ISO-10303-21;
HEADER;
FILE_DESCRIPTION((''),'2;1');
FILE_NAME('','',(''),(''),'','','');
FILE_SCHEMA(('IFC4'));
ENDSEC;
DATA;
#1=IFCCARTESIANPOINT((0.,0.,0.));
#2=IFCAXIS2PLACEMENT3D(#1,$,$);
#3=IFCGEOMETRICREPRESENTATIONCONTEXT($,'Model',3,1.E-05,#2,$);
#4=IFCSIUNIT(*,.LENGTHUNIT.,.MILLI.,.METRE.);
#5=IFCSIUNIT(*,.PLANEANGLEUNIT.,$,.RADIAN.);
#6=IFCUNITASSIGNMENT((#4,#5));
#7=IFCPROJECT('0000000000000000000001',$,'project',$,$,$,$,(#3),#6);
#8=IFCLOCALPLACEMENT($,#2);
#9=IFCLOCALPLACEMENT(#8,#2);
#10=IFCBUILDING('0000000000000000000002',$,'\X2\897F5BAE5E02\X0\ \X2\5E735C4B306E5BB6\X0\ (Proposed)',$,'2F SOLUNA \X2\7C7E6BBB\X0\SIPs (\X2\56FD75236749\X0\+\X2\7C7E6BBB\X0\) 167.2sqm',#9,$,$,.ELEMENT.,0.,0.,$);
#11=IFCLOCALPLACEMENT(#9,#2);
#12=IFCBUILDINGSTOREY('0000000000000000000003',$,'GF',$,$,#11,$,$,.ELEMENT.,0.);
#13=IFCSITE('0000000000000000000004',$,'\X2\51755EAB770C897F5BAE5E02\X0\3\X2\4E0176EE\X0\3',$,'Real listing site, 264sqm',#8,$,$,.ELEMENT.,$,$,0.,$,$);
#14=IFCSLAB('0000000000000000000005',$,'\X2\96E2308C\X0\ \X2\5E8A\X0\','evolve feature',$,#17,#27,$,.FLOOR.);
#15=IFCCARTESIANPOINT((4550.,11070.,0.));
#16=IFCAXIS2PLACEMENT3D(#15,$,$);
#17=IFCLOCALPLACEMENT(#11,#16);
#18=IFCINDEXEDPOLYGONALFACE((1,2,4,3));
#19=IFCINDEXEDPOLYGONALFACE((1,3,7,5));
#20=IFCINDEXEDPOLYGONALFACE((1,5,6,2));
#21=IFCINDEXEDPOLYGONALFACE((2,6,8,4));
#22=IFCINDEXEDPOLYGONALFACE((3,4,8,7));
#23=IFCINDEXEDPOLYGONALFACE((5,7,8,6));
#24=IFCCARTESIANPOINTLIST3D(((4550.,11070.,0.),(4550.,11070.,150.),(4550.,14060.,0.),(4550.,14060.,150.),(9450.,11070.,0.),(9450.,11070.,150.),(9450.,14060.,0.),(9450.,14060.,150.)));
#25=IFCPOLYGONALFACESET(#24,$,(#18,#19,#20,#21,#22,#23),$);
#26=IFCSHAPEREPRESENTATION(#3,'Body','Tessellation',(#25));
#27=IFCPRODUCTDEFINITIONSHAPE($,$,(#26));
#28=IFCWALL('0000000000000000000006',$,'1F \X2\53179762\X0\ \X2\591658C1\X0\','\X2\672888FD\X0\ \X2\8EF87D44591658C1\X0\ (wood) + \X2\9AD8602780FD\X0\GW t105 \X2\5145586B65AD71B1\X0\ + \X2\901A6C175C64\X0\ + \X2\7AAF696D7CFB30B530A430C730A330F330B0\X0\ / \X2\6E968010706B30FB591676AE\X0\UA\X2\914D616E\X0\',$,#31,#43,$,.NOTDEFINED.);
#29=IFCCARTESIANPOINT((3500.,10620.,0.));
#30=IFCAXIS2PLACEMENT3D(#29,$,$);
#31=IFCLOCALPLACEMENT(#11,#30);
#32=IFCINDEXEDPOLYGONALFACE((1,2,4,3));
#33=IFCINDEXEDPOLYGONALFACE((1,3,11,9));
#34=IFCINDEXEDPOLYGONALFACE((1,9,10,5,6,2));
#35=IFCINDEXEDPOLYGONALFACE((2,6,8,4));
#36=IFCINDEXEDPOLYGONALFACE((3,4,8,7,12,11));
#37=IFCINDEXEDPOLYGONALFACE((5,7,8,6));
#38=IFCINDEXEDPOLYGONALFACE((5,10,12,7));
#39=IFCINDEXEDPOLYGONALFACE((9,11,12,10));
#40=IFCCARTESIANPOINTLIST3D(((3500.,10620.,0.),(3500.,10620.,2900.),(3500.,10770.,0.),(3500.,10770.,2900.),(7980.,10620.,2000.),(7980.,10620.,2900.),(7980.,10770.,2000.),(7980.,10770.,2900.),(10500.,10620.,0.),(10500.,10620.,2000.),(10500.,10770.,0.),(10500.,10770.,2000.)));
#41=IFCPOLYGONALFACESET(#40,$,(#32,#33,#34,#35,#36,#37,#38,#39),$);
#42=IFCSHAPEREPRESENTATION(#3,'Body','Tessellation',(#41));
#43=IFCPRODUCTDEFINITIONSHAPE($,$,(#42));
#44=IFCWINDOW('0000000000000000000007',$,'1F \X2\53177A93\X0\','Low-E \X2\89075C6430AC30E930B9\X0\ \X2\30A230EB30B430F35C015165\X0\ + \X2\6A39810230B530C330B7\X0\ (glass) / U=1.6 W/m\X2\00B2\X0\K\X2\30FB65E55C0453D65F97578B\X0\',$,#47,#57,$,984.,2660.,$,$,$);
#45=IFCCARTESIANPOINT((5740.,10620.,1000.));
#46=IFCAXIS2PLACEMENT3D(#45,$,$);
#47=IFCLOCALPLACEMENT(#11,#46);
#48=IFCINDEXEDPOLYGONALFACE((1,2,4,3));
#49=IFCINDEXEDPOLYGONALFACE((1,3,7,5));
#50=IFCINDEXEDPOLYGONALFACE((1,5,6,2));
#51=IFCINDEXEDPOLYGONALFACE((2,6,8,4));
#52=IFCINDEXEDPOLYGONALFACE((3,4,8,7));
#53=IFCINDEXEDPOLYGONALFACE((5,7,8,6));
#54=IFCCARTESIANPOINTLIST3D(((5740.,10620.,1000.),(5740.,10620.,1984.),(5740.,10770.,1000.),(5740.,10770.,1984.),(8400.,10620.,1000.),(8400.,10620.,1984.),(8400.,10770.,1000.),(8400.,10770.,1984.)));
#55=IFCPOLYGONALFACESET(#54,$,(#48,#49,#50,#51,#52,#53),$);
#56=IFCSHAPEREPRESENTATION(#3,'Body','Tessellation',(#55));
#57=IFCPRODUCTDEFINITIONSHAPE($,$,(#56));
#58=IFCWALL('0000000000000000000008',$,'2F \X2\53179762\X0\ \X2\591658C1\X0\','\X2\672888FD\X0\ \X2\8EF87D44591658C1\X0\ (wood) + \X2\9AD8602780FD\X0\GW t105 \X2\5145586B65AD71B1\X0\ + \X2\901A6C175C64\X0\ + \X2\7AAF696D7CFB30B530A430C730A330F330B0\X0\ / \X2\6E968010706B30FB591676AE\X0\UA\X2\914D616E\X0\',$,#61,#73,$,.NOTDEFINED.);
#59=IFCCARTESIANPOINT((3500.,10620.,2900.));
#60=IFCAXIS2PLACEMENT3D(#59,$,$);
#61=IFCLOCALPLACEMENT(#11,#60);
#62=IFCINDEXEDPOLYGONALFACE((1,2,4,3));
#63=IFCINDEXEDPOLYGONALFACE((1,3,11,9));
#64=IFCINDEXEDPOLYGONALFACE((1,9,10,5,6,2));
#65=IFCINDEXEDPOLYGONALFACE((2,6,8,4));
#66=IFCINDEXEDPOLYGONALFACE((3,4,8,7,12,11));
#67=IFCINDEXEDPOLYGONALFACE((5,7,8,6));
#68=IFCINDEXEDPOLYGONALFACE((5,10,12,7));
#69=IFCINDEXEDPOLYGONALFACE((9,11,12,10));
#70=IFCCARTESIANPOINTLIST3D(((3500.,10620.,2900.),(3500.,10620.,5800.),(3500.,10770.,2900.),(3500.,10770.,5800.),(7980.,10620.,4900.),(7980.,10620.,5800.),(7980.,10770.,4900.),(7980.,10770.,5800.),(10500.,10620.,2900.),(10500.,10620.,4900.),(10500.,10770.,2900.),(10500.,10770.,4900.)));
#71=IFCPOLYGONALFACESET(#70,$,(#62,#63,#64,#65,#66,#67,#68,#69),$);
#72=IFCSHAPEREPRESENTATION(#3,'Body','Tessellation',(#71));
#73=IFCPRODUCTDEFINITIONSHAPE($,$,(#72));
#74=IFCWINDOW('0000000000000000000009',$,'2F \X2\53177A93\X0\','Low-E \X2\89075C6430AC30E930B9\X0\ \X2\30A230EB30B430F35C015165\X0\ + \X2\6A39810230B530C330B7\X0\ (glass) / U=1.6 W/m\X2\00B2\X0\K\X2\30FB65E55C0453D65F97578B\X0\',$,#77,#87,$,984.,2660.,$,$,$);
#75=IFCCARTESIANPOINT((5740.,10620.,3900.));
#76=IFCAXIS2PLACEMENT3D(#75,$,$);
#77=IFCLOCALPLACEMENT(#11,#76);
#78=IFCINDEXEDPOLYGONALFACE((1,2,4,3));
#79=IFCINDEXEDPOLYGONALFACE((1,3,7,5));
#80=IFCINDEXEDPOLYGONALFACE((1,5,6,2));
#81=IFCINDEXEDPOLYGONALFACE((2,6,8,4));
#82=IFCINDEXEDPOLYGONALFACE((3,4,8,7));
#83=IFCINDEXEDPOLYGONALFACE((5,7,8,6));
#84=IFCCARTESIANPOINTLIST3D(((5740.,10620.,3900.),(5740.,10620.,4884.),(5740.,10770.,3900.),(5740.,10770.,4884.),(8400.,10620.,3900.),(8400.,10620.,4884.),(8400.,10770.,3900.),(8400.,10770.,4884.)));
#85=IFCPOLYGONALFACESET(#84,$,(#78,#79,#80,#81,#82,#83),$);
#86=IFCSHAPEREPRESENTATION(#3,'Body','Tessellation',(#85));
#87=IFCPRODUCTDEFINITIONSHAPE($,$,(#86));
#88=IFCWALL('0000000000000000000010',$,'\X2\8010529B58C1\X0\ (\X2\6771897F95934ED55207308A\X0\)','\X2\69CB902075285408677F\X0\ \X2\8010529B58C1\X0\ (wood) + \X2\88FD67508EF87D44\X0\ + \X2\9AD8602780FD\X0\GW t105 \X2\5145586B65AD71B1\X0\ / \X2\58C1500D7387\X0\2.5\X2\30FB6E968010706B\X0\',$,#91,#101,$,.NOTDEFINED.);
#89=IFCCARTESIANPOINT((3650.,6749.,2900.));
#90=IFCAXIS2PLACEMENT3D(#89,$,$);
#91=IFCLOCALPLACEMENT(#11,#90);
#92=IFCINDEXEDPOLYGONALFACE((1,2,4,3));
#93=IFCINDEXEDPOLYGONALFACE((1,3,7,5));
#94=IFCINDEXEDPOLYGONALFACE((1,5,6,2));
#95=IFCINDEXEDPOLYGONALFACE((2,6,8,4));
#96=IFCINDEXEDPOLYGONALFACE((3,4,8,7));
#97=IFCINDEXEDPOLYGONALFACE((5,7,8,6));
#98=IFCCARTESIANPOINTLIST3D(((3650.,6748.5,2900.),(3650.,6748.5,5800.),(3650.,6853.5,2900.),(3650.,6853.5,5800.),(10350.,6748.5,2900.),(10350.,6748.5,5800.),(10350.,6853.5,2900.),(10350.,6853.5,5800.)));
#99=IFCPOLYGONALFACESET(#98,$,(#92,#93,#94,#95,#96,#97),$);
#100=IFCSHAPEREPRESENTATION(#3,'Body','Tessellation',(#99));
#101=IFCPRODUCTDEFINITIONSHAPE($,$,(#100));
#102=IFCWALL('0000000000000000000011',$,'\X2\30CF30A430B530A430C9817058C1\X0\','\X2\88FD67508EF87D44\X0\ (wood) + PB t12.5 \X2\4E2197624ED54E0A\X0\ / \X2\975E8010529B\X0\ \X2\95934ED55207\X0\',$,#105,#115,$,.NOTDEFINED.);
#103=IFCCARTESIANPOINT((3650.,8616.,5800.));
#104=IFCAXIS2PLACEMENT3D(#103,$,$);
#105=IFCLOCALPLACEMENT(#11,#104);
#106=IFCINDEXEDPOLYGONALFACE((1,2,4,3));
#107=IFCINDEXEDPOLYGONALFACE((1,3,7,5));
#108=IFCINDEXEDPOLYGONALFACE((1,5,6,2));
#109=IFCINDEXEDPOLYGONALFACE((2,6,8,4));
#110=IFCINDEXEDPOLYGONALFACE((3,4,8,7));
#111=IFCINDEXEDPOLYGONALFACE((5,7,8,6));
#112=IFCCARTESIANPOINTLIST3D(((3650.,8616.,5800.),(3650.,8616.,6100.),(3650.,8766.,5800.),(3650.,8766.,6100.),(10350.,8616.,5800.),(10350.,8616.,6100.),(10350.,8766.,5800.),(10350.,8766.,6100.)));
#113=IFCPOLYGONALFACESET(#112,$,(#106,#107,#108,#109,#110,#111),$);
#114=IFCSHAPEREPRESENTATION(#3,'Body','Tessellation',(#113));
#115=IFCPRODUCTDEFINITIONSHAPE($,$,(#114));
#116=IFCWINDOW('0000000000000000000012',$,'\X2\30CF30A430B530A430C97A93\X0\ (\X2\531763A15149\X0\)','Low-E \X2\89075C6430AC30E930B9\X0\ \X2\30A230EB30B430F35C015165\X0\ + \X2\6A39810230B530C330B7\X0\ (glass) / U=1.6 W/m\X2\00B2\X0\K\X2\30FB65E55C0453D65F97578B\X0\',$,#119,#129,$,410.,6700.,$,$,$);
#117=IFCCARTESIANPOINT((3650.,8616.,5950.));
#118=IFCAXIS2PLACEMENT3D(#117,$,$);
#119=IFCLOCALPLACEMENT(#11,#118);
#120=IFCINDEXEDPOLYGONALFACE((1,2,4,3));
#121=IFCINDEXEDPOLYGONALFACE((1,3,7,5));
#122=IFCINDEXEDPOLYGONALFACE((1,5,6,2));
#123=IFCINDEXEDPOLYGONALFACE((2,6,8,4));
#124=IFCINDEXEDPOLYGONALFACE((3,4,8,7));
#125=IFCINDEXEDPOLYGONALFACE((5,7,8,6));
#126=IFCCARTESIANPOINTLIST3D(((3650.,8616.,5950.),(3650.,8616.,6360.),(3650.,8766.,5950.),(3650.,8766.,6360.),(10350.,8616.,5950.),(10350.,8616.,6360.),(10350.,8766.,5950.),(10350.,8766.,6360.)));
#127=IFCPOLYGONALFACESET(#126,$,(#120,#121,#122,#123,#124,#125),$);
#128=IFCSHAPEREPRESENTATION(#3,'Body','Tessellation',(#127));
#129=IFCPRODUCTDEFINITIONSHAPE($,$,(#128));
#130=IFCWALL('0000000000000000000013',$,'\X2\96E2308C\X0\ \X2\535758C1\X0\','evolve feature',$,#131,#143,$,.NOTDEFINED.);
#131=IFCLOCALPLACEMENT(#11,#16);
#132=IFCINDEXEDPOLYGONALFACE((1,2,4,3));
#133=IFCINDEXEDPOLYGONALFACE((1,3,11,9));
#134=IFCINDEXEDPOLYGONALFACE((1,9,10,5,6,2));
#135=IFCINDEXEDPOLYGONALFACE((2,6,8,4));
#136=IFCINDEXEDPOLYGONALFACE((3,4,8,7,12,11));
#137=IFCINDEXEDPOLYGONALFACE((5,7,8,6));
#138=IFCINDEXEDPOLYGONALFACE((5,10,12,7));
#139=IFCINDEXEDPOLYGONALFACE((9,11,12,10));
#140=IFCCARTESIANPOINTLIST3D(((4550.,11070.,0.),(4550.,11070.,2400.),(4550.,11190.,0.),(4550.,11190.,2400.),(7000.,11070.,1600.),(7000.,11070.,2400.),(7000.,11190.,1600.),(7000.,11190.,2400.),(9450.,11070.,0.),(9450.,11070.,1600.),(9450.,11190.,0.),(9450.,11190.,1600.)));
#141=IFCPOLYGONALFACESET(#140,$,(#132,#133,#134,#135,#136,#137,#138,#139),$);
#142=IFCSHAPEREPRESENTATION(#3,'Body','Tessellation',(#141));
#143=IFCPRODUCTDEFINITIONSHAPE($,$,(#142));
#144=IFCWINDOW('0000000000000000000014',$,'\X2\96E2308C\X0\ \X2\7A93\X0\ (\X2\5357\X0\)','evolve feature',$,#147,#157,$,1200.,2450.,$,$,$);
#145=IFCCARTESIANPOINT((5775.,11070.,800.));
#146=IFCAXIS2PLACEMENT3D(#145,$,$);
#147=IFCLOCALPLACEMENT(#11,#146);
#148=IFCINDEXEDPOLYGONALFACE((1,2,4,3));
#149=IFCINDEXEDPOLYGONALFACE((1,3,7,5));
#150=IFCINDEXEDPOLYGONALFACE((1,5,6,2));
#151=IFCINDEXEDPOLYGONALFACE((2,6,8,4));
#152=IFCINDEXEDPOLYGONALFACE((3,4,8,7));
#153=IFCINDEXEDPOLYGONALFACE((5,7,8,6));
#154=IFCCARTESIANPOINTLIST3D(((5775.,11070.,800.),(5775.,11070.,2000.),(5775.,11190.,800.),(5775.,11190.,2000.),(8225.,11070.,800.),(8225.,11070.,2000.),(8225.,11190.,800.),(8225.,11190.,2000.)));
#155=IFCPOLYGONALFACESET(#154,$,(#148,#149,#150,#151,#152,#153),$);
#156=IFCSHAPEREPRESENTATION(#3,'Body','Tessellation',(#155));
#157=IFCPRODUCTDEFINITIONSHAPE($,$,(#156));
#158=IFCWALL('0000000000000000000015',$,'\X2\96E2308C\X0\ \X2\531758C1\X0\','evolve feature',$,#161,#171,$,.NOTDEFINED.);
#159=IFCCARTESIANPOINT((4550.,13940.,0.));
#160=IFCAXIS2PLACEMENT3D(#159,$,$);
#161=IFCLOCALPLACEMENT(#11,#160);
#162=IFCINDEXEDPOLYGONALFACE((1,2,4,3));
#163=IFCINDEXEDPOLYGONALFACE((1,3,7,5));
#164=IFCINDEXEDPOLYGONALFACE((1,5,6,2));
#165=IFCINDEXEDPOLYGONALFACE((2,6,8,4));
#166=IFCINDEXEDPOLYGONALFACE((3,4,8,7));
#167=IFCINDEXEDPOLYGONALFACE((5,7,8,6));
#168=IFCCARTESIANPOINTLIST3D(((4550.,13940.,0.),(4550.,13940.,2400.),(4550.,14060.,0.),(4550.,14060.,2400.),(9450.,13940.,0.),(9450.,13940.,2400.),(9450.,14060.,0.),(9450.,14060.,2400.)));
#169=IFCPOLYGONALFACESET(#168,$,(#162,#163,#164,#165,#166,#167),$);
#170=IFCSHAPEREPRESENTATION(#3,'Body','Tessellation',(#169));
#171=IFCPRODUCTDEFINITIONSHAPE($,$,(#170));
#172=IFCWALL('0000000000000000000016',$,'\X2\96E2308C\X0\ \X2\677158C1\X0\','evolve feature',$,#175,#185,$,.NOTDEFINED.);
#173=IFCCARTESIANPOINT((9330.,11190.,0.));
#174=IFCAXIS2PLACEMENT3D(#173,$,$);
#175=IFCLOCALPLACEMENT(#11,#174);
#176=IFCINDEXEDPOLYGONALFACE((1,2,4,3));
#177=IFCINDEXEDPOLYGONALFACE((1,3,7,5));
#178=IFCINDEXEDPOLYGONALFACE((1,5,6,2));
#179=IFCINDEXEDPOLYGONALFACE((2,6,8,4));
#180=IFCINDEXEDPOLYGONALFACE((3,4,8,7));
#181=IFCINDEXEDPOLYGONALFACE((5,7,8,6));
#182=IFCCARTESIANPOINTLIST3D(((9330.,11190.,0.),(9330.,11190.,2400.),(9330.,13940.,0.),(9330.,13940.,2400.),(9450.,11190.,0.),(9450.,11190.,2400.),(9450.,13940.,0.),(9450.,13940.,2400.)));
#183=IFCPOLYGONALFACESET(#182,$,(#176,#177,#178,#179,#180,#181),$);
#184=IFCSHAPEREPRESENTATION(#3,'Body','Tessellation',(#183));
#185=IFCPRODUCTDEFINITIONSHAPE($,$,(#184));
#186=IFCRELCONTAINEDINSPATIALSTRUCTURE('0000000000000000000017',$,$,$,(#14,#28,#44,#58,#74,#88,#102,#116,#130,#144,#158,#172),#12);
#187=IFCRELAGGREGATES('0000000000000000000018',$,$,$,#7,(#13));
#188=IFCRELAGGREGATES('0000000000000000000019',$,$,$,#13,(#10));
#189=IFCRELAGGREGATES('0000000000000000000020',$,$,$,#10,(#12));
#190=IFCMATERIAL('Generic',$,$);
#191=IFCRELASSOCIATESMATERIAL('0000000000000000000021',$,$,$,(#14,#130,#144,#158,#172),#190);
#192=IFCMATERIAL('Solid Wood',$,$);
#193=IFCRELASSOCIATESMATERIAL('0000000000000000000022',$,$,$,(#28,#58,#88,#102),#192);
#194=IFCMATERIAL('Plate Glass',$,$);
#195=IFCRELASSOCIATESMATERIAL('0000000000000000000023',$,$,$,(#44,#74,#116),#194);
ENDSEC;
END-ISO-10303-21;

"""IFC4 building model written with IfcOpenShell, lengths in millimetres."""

from ifc_helpers import new_model, si_unit, frame, frame_2d, origin, place, context, project, spatial, rectangle, extrude, material, element, fill, save


model = new_model("IFC4")

# Units and contexts
model_context = context("Model", 3, precision=1e-05, world=origin())
ifc_project = project(units=[si_unit("LENGTHUNIT", "METRE", prefix="MILLI"), si_unit("PLANEANGLEUNIT", "RADIAN")], contexts=[model_context])

# Site, building, storey
site_placement = place(None, origin())
site = spatial("IfcSite", under=ifc_project, at=site_placement, Name="兵庫県西宮市3丁目3", ObjectType="Real listing site, 264sqm", CompositionType="ELEMENT", RefElevation=0.0)
building_placement = place(site_placement, origin())
building = spatial("IfcBuilding", under=site, at=building_placement, Name="西宮市 平屋の家 (Proposed)", ObjectType="2F SOLUNA 籾殻SIPs (国産杉+籾殻) 167.2sqm", CompositionType="ELEMENT", ElevationOfRefHeight=0.0, ElevationOfTerrain=0.0)
storey_placement = place(building_placement, origin())
storey = spatial("IfcBuildingStorey", under=building, at=storey_placement, Name="GF", CompositionType="ELEMENT", Elevation=0.0)

# Slab
ifc_material_1 = material(Name="Generic")
slab_placement = place(storey_placement, frame((4550.0, 11070.0, 0.0)))
element("IfcSlab", 1, at=slab_placement, inside=storey, material=ifc_material_1, Name="離れ 床", Description="evolve feature", PredefinedType="FLOOR", context=model_context, shape_type="SweptSolid", body=[
    extrude(rectangle(XDim=4900.0, YDim=2990.0, at=frame_2d((2450.0, 1495.0))), frame((4550.0, 11070.0, 0.0)), (0.0, 0.0, 1.0), 150.0),
])

# Wall, opening, window
ifc_material_2 = material(Name="Solid Wood")
wall_1_placement = place(storey_placement, frame((3500.0, 10620.0, 0.0)))
wall_1 = element("IfcWall", 2, at=wall_1_placement, inside=storey, material=ifc_material_2, Name="1F 北面 外壁", Description="木製 軸組外壁 (wood) + 高性能GW t105 充填断熱 + 通気層 + 窯業系サイディング / 準耐火・外皮UA配慮", PredefinedType="NOTDEFINED", context=model_context, shape_type="SweptSolid", body=[
    extrude(rectangle(XDim=7000.0, YDim=150.0, at=frame_2d((3500.0, 75.0))), frame((3500.0, 10620.0, 0.0)), (0.0, 0.0, 1.0), 2900.0),
])
opening_1_placement = place(storey_placement, frame((5740.0, 10620.0, 1000.0)))
opening_1 = element("IfcOpeningElement", 3, at=opening_1_placement, cuts=wall_1, PredefinedType="NOTDEFINED", context=model_context, shape_type="SweptSolid", body=[
    extrude(rectangle(XDim=2660.0, YDim=150.0, at=frame_2d((1330.0, 75.0))), frame((5740.0, 10620.0, 1000.0)), (0.0, 0.0, 1.0), 984.0),
])
ifc_material_3 = material(Name="Plate Glass")
window_1_placement = place(storey_placement, frame((5740.0, 10620.0, 1000.0)))
window_1 = element("IfcWindow", 4, at=window_1_placement, inside=storey, material=ifc_material_3, Name="1F 北窓", Description="Low-E 複層ガラス アルゴン封入 + 樹脂サッシ (glass) / U=1.6 W/m²K・日射取得型", OverallHeight=984.0, OverallWidth=2660.0, context=model_context, shape_type="SweptSolid", body=[
    extrude(rectangle(XDim=2660.0, YDim=150.0, at=frame_2d((1330.0, 75.0))), frame((5740.0, 10620.0, 1000.0)), (0.0, 0.0, 1.0), 984.0),
])
fill(opening_1, window_1)

# Wall, opening, window
wall_2_placement = place(storey_placement, frame((3500.0, 10620.0, 2900.0)))
wall_2 = element("IfcWall", 5, at=wall_2_placement, inside=storey, material=ifc_material_2, Name="2F 北面 外壁", Description="木製 軸組外壁 (wood) + 高性能GW t105 充填断熱 + 通気層 + 窯業系サイディング / 準耐火・外皮UA配慮", PredefinedType="NOTDEFINED", context=model_context, shape_type="SweptSolid", body=[
    extrude(rectangle(XDim=7000.0, YDim=150.0, at=frame_2d((3500.0, 75.0))), frame((3500.0, 10620.0, 2900.0)), (0.0, 0.0, 1.0), 2900.0),
])
opening_2_placement = place(storey_placement, frame((5740.0, 10620.0, 3900.0)))
opening_2 = element("IfcOpeningElement", 6, at=opening_2_placement, cuts=wall_2, PredefinedType="NOTDEFINED", context=model_context, shape_type="SweptSolid", body=[
    extrude(rectangle(XDim=2660.0, YDim=150.0, at=frame_2d((1330.0, 75.0))), frame((5740.0, 10620.0, 3900.0)), (0.0, 0.0, 1.0), 984.0),
])
window_2_placement = place(storey_placement, frame((5740.0, 10620.0, 3900.0)))
window_2 = element("IfcWindow", 7, at=window_2_placement, inside=storey, material=ifc_material_3, Name="2F 北窓", Description="Low-E 複層ガラス アルゴン封入 + 樹脂サッシ (glass) / U=1.6 W/m²K・日射取得型", OverallHeight=984.0, OverallWidth=2660.0, context=model_context, shape_type="SweptSolid", body=[
    extrude(rectangle(XDim=2660.0, YDim=150.0, at=frame_2d((1330.0, 75.0))), frame((5740.0, 10620.0, 3900.0)), (0.0, 0.0, 1.0), 984.0),
])
fill(opening_2, window_2)

# Wall
wall_3_placement = place(storey_placement, frame((3650.0, 6749.0, 2900.0)))
element("IfcWall", 8, at=wall_3_placement, inside=storey, material=ifc_material_2, Name="耐力壁 (東西間仕切り)", Description="構造用合板 耐力壁 (wood) + 製材軸組 + 高性能GW t105 充填断熱 / 壁倍率2.5・準耐火", PredefinedType="NOTDEFINED", context=model_context, shape_type="SweptSolid", body=[
    extrude(rectangle(XDim=6700.0, YDim=105.0, at=frame_2d((3350.0, 52.0))), frame((3650.0, 6749.0, 2900.0)), (0.0, 0.0, 1.0), 2900.0),
])

# Walls, openings, windows
wall_4_placement = place(storey_placement, frame((3650.0, 8616.0, 5800.0)))
wall_4 = element("IfcWall", 9, at=wall_4_placement, inside=storey, material=ifc_material_2, Name="ハイサイド腰壁", Description="製材軸組 (wood) + PB t12.5 両面仕上 / 非耐力 間仕切", PredefinedType="NOTDEFINED", context=model_context, shape_type="SweptSolid", body=[
    extrude(rectangle(XDim=6700.0, YDim=150.0, at=frame_2d((3350.0, 75.0))), frame((3650.0, 8616.0, 5800.0)), (0.0, 0.0, 1.0), 700.0),
])
opening_3_placement = place(storey_placement, frame((3650.0, 8616.0, 5950.0)))
opening_3 = element("IfcOpeningElement", 10, at=opening_3_placement, cuts=wall_4, PredefinedType="NOTDEFINED", context=model_context, shape_type="SweptSolid", body=[
    extrude(rectangle(XDim=6700.0, YDim=150.0, at=frame_2d((3350.0, 75.0))), frame((3650.0, 8616.0, 5950.0)), (0.0, 0.0, 1.0), 410.0),
])
window_3_placement = place(storey_placement, frame((3650.0, 8616.0, 5950.0)))
window_3 = element("IfcWindow", 11, at=window_3_placement, inside=storey, material=ifc_material_3, Name="ハイサイド窓 (北採光)", Description="Low-E 複層ガラス アルゴン封入 + 樹脂サッシ (glass) / U=1.6 W/m²K・日射取得型", OverallHeight=410.0, OverallWidth=6700.0, context=model_context, shape_type="SweptSolid", body=[
    extrude(rectangle(XDim=6700.0, YDim=150.0, at=frame_2d((3350.0, 75.0))), frame((3650.0, 8616.0, 5950.0)), (0.0, 0.0, 1.0), 410.0),
])
fill(opening_3, window_3)
wall_5_placement = place(storey_placement, frame((4550.0, 11070.0, 0.0)))
wall_5 = element("IfcWall", 12, at=wall_5_placement, inside=storey, material=ifc_material_1, Name="離れ 南壁", Description="evolve feature", PredefinedType="NOTDEFINED", context=model_context, shape_type="SweptSolid", body=[
    extrude(rectangle(XDim=4900.0, YDim=120.0, at=frame_2d((2450.0, 60.0))), frame((4550.0, 11070.0, 0.0)), (0.0, 0.0, 1.0), 2400.0),
])
opening_4_placement = place(storey_placement, frame((5775.0, 11070.0, 800.0)))
opening_4 = element("IfcOpeningElement", 13, at=opening_4_placement, cuts=wall_5, PredefinedType="NOTDEFINED", context=model_context, shape_type="SweptSolid", body=[
    extrude(rectangle(XDim=2450.0, YDim=120.0, at=frame_2d((1225.0, 60.0))), frame((5775.0, 11070.0, 800.0)), (0.0, 0.0, 1.0), 1200.0),
])
window_4_placement = place(storey_placement, frame((5775.0, 11070.0, 800.0)))
window_4 = element("IfcWindow", 14, at=window_4_placement, inside=storey, material=ifc_material_1, Name="離れ 窓 (南)", Description="evolve feature", OverallHeight=1200.0, OverallWidth=2450.0, context=model_context, shape_type="SweptSolid", body=[
    extrude(rectangle(XDim=2450.0, YDim=120.0, at=frame_2d((1225.0, 60.0))), frame((5775.0, 11070.0, 800.0)), (0.0, 0.0, 1.0), 1200.0),
])
fill(opening_4, window_4)

# Walls
wall_6_placement = place(storey_placement, frame((4550.0, 13940.0, 0.0)))
element("IfcWall", 15, at=wall_6_placement, inside=storey, material=ifc_material_1, Name="離れ 北壁", Description="evolve feature", PredefinedType="NOTDEFINED", context=model_context, shape_type="SweptSolid", body=[
    extrude(rectangle(XDim=4900.0, YDim=120.0, at=frame_2d((2450.0, 60.0))), frame((4550.0, 13940.0, 0.0)), (0.0, 0.0, 1.0), 2400.0),
])
wall_7_placement = place(storey_placement, frame((9330.0, 11190.0, 0.0)))
element("IfcWall", 16, at=wall_7_placement, inside=storey, material=ifc_material_1, Name="離れ 東壁", Description="evolve feature", PredefinedType="NOTDEFINED", context=model_context, shape_type="SweptSolid", body=[
    extrude(rectangle(XDim=120.0, YDim=2750.0, at=frame_2d((60.0, 1375.0))), frame((9330.0, 11190.0, 0.0)), (0.0, 0.0, 1.0), 2400.0),
])

save(model, "model.ifc")
